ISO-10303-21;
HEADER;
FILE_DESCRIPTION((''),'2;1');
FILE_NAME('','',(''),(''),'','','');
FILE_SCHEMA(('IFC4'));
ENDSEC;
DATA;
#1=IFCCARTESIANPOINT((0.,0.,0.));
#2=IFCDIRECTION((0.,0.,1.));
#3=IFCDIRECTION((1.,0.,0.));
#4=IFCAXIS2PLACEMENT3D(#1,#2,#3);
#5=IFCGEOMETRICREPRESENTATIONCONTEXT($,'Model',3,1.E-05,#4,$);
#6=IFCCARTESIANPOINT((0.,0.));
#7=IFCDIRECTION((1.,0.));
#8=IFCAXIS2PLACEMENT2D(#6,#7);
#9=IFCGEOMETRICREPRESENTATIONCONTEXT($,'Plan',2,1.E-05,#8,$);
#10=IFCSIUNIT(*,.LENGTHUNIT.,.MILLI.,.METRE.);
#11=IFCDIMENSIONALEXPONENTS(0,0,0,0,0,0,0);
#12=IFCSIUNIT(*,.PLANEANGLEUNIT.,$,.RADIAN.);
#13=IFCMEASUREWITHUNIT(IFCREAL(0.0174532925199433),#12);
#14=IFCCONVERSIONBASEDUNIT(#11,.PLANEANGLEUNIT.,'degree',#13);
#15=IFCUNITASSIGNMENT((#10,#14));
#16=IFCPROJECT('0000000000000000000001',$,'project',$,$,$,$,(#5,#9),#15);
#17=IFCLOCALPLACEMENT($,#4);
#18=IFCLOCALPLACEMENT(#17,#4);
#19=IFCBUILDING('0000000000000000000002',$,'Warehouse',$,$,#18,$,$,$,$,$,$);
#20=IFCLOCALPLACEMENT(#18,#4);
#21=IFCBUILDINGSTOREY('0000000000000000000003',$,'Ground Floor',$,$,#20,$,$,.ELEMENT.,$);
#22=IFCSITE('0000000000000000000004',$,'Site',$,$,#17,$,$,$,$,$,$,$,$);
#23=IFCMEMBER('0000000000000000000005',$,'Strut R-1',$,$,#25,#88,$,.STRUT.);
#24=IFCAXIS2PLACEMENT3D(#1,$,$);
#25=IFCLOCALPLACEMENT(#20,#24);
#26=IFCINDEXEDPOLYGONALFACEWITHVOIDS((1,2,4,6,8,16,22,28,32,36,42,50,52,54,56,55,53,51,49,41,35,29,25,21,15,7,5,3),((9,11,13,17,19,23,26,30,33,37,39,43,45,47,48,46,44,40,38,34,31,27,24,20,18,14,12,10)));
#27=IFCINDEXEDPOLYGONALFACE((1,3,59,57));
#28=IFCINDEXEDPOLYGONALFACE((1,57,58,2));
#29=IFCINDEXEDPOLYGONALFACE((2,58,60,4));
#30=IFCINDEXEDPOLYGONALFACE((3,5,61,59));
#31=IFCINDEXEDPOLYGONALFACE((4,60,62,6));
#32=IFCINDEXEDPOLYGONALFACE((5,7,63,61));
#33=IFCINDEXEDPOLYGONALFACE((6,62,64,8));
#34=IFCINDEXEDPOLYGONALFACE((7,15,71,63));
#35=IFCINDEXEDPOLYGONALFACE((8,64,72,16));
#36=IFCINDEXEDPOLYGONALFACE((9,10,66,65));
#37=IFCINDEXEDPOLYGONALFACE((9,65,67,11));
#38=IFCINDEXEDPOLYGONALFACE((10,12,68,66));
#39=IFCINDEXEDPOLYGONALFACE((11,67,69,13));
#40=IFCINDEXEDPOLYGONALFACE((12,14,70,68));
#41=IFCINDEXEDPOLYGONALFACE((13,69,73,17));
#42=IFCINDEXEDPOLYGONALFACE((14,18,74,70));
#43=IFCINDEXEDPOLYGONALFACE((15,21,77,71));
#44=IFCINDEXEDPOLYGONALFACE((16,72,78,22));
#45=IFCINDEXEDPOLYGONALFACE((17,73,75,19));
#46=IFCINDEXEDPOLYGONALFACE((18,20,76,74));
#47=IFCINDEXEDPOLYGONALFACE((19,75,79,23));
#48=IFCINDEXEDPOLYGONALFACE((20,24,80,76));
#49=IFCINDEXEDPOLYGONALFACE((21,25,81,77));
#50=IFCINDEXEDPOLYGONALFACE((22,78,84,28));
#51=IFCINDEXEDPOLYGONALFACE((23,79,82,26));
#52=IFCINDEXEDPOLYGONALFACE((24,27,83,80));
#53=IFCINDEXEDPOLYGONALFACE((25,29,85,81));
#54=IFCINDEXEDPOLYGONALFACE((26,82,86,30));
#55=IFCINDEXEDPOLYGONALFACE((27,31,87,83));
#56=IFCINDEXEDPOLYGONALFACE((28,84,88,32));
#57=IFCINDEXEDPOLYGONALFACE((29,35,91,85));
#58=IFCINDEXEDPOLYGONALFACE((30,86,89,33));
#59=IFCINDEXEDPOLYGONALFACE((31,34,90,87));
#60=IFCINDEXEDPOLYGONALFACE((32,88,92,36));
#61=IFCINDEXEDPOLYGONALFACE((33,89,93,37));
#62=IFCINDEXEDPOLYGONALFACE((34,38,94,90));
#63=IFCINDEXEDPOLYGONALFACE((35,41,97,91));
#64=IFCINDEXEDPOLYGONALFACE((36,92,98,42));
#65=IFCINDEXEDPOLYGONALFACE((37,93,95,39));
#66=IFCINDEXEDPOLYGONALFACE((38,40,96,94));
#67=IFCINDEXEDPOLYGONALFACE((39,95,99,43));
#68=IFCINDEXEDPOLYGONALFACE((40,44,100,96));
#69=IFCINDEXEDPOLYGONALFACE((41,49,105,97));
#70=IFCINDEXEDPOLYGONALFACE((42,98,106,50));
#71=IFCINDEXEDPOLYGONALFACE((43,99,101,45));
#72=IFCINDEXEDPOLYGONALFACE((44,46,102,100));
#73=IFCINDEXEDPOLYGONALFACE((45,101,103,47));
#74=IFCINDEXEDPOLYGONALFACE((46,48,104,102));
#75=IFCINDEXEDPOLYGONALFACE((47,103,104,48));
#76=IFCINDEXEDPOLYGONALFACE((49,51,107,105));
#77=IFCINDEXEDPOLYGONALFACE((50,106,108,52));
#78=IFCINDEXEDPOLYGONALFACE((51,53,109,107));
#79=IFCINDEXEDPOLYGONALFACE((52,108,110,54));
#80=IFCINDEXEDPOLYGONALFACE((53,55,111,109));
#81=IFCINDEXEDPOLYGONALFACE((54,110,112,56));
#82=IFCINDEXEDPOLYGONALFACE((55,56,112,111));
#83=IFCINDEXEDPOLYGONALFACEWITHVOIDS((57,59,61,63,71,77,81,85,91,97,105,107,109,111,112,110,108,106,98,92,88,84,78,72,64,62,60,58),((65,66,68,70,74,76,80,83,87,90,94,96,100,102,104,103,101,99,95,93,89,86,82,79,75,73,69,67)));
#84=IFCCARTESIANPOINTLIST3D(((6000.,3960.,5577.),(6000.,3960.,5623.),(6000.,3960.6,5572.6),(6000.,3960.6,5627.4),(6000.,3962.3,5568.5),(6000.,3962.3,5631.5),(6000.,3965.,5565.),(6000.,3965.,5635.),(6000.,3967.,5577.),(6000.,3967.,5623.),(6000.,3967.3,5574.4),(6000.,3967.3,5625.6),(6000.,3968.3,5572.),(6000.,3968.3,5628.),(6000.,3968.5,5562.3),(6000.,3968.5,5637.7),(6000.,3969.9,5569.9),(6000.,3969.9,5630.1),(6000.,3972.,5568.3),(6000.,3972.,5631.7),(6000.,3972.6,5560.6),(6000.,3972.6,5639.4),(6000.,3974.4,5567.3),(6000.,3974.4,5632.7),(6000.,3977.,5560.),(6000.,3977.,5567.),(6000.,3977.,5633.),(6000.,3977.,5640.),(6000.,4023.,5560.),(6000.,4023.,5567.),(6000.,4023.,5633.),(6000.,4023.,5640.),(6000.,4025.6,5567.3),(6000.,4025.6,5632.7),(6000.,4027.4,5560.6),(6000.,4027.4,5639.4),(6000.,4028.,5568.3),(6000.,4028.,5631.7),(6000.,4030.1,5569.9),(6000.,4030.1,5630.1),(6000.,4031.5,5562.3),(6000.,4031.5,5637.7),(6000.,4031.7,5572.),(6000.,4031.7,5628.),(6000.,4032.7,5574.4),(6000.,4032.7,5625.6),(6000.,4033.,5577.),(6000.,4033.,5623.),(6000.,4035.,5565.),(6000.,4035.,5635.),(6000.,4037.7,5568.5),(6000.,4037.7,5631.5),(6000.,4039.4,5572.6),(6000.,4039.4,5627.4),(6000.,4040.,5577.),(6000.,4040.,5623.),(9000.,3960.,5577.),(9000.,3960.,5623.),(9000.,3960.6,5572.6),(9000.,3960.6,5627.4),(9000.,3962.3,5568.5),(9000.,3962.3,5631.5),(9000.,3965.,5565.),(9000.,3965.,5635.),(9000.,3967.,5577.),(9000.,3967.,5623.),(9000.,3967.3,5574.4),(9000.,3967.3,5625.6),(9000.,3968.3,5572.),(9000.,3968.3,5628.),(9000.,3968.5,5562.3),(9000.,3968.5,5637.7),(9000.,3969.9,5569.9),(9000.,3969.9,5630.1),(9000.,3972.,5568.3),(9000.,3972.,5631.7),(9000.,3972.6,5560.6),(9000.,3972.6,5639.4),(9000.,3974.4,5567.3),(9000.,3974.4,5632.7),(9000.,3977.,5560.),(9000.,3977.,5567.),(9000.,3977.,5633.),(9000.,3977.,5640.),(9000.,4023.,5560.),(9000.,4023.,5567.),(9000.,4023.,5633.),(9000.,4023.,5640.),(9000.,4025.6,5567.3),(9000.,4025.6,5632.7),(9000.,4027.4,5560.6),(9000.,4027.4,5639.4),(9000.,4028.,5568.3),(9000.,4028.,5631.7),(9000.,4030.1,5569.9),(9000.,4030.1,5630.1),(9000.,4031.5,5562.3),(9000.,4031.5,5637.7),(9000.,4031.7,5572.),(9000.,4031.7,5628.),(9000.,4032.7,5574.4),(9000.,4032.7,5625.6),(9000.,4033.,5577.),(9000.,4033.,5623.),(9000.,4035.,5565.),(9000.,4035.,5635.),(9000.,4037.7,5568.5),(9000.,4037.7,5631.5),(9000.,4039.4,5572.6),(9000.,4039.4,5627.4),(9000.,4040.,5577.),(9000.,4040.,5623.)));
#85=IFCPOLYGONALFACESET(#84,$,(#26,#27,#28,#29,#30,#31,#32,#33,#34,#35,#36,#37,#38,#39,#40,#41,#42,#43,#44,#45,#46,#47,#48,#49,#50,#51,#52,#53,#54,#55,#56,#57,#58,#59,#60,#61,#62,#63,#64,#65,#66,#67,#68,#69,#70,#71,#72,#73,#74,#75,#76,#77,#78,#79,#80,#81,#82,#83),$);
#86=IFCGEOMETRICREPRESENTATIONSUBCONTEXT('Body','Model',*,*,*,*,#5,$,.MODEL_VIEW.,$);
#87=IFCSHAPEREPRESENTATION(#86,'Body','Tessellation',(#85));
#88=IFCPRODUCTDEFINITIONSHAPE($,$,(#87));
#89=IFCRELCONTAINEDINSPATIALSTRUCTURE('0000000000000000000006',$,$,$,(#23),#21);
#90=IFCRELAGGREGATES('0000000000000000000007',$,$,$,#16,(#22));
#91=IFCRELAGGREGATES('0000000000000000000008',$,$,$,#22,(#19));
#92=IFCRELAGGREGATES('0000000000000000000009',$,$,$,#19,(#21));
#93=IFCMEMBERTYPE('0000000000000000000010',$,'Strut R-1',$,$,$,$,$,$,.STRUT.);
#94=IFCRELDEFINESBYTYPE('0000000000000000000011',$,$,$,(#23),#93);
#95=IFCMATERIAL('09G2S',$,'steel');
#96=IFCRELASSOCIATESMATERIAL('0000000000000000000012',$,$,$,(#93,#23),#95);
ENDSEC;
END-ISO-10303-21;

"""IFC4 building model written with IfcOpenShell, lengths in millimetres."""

from ifc_helpers import new_model, entity, si_unit, converted_unit, frame, origin_with_axes, origin_2d_with_axis, place, context, subcontext, project, spatial, hollow_rectangle, extrude, material, material_profile, profile_set, profile_usage, type_object, element, save


model = new_model("IFC4")

# Units and contexts
model_context = context("Model", 3, precision=1e-05, world=origin_with_axes())
plan_context = context("Plan", 2, precision=1e-05, world=origin_2d_with_axis())
body_context = subcontext(model_context, "Body", "Model", "MODEL_VIEW")
ifc_project = project(units=[si_unit("LENGTHUNIT", "METRE", prefix="MILLI"), converted_unit("PLANEANGLEUNIT", "degree", entity("IfcReal", 0.0174532925199433), si_unit("PLANEANGLEUNIT", "RADIAN"), dimensions=[0, 0, 0, 0, 0, 0, 0])], contexts=[model_context, plan_context])

# Site, building, storey
site_placement = place(None, origin_with_axes())
site = spatial("IfcSite", under=ifc_project, at=site_placement, Name="Site")
building_placement = place(site_placement, origin_with_axes())
building = spatial("IfcBuilding", under=site, at=building_placement, Name="Warehouse")
storey_placement = place(building_placement, origin_with_axes())
storey = spatial("IfcBuildingStorey", under=building, at=storey_placement, Name="Ground Floor", CompositionType="ELEMENT")

# Member
ifc_material_1 = material(Name="09G2S", Category="steel")
ifc_material_profile_1 = material_profile(ifc_material_1, hollow_rectangle(XDim=80.0, YDim=80.0, WallThickness=7.0, InnerFilletRadius=10.0, OuterFilletRadius=17.0))
ifc_profile_set_1 = profile_set([ifc_material_profile_1], Name="PK80x7_09G2S")
member_type_1 = type_object("IfcMemberType", Name="Strut R-1", PredefinedType="STRUT", material=ifc_profile_set_1)
ifc_profile_usage_1 = profile_usage(ifc_profile_set_1, cardinal=5)
member_1_placement = place(storey_placement, frame((6000.0, 4000.0, 5600.0), z_axis=(1.0, 0.0, 0.0), x_axis=(0.0, 1.0, 0.0)))
element("IfcMember", 1, at=member_1_placement, inside=storey, type_object=member_type_1, material=ifc_profile_usage_1, Name="Strut R-1", PredefinedType="STRUT", context=body_context, shape_type="SweptSolid", body=[
    extrude(hollow_rectangle(XDim=80.0, YDim=80.0, WallThickness=7.0, InnerFilletRadius=10.0, OuterFilletRadius=17.0), origin_with_axes(), (0.0, 0.0, 1.0), 3000.0),
])

save(model, "model.ifc")
